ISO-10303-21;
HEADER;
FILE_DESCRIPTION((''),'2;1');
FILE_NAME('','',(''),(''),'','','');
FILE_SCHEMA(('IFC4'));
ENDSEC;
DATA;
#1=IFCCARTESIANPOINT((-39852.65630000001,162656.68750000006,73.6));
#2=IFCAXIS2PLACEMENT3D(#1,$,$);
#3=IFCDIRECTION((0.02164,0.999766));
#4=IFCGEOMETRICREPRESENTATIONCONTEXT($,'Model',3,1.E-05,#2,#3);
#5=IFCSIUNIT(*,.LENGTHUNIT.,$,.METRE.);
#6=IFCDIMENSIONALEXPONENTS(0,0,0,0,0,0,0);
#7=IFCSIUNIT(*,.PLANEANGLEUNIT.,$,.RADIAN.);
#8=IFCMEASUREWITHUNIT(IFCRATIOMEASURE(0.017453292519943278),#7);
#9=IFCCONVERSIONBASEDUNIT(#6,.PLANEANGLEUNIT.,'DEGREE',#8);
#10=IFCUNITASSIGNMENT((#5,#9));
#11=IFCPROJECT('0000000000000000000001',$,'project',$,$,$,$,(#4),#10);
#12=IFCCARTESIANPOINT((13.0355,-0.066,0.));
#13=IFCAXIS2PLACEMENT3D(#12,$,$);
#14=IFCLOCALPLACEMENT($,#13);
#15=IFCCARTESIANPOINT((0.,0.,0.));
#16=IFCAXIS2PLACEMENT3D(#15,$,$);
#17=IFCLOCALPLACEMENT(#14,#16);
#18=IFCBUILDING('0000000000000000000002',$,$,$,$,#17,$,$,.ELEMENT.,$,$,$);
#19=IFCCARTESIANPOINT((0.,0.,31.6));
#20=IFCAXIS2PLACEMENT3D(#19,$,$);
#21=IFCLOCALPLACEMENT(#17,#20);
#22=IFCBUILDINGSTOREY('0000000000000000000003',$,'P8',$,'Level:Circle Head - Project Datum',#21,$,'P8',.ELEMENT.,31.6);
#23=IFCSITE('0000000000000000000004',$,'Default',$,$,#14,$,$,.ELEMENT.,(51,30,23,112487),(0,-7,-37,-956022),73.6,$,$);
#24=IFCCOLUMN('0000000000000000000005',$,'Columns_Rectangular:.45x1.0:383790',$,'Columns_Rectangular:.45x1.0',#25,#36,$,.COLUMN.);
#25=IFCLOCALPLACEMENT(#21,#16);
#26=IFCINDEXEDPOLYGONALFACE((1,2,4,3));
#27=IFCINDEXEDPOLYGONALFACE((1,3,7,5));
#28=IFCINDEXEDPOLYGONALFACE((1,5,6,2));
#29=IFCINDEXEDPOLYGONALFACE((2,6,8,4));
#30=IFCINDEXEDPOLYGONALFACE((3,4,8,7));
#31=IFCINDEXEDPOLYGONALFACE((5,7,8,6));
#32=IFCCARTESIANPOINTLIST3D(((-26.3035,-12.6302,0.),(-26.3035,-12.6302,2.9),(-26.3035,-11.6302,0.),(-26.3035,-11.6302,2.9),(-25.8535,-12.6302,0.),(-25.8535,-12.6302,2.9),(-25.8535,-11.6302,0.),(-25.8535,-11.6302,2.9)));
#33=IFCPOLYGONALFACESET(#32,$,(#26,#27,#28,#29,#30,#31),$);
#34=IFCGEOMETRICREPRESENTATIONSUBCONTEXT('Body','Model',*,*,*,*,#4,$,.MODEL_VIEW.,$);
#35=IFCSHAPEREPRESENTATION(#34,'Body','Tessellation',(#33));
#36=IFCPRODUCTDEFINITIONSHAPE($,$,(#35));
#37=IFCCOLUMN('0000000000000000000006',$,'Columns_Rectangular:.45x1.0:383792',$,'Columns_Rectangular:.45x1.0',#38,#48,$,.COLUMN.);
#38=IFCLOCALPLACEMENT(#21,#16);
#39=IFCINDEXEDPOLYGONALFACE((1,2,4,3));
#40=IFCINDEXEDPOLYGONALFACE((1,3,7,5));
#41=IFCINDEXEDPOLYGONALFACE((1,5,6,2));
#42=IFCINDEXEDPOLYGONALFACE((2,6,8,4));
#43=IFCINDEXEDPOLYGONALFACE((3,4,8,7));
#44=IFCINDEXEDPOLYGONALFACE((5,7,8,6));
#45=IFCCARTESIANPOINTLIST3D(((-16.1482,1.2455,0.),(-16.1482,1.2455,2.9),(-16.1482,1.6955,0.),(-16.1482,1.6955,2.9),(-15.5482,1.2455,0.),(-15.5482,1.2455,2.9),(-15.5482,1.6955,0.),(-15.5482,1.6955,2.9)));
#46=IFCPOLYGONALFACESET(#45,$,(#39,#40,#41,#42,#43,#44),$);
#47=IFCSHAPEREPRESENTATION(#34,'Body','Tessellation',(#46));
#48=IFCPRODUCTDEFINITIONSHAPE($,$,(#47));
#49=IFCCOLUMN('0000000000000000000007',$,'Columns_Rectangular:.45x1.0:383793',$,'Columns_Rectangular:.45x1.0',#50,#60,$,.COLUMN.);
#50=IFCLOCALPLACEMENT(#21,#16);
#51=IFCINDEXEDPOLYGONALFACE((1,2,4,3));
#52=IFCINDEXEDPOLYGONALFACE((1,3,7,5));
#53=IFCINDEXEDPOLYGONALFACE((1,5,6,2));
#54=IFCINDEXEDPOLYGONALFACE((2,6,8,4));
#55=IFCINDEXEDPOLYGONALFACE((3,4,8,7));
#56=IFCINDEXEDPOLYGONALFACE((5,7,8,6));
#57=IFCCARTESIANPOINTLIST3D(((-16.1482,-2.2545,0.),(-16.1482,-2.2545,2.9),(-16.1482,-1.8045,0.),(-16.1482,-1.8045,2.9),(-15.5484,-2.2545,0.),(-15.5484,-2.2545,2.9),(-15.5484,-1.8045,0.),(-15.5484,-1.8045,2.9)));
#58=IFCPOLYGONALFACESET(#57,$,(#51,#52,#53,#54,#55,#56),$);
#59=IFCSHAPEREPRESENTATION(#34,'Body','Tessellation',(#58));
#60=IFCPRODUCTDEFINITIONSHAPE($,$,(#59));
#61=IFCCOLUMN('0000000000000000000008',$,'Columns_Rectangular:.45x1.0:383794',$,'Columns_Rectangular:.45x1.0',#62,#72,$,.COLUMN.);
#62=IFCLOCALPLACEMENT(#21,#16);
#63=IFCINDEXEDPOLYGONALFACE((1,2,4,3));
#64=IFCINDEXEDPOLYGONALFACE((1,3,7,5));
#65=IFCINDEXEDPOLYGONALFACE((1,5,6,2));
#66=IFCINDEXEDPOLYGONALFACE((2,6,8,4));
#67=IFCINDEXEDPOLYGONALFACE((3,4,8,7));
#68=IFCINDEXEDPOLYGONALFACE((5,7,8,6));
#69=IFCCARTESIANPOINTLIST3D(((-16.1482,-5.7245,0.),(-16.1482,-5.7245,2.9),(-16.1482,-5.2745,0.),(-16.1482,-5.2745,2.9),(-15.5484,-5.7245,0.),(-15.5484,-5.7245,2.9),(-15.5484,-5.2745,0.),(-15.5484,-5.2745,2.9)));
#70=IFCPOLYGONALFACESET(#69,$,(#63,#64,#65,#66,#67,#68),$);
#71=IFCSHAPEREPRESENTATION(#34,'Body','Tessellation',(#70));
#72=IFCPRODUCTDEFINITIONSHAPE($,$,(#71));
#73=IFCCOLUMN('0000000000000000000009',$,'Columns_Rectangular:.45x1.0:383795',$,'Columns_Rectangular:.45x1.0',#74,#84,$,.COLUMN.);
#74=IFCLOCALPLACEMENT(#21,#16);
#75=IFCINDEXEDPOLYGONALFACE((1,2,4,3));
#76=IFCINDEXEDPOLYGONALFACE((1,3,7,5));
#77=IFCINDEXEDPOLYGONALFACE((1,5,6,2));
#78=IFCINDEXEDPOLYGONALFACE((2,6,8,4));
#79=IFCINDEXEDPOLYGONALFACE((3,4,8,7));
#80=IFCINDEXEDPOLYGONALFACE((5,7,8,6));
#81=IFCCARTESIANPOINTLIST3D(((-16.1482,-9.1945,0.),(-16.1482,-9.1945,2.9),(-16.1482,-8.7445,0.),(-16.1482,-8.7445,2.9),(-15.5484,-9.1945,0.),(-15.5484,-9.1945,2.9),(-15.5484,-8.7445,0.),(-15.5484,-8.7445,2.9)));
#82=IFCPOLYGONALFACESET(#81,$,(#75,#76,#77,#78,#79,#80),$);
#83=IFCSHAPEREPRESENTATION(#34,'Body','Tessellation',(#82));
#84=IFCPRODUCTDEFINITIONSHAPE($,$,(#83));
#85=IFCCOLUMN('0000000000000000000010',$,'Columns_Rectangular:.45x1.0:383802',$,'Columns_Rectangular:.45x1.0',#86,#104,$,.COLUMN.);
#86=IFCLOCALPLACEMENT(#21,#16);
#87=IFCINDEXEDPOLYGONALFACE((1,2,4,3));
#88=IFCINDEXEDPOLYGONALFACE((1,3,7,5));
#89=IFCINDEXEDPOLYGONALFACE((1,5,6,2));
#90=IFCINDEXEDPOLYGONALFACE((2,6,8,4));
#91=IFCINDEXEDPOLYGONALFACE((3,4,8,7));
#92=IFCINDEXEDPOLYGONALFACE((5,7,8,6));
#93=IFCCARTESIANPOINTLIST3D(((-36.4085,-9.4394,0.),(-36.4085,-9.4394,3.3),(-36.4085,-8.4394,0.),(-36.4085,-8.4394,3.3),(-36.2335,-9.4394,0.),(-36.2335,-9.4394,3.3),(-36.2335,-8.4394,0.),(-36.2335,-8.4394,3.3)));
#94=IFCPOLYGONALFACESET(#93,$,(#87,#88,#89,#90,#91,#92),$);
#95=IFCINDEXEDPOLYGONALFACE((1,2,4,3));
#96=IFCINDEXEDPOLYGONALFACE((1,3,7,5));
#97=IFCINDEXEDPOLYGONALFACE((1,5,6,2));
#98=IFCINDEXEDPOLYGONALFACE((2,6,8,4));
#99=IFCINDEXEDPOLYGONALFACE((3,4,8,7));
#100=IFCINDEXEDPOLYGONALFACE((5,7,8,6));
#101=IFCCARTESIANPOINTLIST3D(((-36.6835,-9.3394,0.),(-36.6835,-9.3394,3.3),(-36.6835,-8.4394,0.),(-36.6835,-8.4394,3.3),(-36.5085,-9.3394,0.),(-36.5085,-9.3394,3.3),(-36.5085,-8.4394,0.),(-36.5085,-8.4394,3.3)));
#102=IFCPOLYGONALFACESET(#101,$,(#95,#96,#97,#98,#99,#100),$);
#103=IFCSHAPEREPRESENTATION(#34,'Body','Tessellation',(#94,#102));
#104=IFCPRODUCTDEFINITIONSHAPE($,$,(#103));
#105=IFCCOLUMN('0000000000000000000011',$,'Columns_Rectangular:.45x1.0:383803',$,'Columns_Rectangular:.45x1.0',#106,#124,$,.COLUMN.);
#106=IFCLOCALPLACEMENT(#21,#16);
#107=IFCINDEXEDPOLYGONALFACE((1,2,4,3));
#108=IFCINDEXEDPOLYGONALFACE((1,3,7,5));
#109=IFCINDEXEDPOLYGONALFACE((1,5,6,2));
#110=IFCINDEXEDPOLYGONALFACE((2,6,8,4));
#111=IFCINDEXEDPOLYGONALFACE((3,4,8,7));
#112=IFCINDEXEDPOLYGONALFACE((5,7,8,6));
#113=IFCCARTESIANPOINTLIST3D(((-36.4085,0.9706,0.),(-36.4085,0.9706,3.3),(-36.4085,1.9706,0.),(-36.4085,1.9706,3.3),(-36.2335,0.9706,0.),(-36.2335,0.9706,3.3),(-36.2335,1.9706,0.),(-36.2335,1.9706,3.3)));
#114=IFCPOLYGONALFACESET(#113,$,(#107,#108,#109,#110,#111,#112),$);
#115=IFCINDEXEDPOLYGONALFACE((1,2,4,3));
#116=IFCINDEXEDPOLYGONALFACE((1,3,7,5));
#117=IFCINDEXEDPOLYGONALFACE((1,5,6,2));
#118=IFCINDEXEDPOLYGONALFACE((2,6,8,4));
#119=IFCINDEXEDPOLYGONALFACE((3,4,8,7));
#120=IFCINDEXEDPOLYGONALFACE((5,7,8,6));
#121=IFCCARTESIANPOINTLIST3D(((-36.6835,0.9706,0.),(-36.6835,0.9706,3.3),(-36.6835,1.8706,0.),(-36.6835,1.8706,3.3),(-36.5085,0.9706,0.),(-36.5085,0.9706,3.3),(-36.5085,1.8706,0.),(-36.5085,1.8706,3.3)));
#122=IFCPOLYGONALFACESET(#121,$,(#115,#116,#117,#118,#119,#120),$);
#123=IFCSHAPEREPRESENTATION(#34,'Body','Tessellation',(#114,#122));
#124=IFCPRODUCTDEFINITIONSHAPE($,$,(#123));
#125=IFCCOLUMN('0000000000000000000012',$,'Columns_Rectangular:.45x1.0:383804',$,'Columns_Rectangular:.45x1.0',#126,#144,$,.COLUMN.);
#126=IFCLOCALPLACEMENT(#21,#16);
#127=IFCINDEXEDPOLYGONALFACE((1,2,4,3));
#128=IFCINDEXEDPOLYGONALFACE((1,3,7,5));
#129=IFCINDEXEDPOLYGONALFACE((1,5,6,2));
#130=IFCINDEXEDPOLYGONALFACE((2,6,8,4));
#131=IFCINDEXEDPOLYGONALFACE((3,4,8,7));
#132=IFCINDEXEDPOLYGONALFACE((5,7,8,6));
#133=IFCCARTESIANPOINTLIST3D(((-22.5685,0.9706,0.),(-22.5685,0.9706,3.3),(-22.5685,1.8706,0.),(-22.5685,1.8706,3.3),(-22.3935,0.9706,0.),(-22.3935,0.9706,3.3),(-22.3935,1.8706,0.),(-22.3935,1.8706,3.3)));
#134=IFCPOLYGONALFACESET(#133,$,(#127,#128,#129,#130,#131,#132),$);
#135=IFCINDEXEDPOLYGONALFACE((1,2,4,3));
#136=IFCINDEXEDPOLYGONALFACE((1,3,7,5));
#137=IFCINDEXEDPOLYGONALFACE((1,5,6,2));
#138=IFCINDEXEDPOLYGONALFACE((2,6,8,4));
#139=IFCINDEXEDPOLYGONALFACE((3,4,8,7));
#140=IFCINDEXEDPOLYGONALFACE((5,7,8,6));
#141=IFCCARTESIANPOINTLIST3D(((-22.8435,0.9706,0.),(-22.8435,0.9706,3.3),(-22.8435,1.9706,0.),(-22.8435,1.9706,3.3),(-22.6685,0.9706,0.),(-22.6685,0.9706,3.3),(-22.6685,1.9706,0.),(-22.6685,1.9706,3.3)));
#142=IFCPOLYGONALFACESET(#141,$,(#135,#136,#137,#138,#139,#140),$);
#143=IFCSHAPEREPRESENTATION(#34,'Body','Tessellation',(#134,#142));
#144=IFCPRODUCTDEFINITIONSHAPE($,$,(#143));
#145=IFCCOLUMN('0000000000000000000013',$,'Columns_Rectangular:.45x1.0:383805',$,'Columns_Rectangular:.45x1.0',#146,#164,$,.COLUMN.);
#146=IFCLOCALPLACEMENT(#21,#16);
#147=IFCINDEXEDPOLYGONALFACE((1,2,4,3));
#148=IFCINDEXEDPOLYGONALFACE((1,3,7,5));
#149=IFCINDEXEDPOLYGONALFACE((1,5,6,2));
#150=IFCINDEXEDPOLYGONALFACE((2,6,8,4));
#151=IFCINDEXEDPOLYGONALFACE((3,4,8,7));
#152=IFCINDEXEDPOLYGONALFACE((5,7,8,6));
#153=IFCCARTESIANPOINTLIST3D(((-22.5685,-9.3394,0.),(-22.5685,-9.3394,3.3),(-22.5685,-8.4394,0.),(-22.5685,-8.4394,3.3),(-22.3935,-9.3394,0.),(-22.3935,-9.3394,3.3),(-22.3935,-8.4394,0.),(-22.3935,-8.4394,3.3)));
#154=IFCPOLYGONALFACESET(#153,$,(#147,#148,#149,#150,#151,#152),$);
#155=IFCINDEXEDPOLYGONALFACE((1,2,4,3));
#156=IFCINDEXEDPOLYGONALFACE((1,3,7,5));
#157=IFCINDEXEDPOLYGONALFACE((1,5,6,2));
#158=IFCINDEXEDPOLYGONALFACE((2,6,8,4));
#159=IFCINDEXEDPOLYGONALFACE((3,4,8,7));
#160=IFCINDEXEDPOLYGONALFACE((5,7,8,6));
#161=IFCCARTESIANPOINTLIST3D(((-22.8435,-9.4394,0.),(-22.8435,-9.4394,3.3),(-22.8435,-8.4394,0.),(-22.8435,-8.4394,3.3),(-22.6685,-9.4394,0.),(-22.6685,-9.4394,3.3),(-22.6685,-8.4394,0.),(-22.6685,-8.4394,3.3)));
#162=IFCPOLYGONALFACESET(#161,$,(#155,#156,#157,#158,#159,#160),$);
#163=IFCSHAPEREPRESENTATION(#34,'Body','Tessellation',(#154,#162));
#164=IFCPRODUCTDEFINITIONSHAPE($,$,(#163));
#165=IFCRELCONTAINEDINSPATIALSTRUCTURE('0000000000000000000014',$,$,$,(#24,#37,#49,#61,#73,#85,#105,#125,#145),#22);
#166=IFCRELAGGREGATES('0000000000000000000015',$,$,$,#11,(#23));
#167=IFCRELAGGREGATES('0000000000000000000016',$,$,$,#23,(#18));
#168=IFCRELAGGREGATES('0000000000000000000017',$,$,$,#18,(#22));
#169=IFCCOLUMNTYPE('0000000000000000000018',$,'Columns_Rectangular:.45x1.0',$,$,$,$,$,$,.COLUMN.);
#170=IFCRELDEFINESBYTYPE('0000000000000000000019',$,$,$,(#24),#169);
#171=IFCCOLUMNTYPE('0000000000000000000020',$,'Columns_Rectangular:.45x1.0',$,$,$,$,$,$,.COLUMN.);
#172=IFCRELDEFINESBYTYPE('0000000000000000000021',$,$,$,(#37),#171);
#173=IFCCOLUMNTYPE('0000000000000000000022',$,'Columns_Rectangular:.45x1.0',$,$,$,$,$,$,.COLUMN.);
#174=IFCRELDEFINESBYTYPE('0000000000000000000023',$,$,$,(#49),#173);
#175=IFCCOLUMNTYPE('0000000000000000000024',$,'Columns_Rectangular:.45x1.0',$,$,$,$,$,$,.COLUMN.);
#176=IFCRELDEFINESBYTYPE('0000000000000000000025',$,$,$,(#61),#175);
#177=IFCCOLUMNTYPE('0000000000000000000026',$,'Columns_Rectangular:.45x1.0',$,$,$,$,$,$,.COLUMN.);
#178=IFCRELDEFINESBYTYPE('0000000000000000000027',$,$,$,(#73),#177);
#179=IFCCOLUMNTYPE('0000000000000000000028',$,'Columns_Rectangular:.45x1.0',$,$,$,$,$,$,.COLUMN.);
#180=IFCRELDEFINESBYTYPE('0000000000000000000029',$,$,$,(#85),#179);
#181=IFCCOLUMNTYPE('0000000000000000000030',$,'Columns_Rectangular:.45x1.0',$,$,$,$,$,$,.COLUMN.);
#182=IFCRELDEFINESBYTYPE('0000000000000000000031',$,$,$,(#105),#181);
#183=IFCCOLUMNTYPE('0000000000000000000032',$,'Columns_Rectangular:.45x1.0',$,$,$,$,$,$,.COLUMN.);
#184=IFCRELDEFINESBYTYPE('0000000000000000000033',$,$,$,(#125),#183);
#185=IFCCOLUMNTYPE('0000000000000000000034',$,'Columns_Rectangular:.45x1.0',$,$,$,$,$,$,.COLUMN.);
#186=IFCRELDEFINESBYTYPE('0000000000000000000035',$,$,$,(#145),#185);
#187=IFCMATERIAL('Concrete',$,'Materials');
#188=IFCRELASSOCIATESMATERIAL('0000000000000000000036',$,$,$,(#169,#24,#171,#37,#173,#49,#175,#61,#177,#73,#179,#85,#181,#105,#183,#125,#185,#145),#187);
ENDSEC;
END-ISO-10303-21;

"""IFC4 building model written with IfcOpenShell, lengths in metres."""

from ifc_helpers import new_model, entity, si_unit, converted_unit, direction, frame, origin, place, context, subcontext, project, spatial, indexed_curve, outline, extrude, source, transform, mapped, material, type_object, type_shapes, element, save


model = new_model("IFC4")

# Units and contexts
model_context = context("Model", 3, precision=1e-05, world=frame((-39852.65630000001, 162656.68750000006, 73.6)), true_north=direction((0.02164, 0.999766)))
body_context = subcontext(model_context, "Body", "Model", "MODEL_VIEW")
ifc_project = project(units=[si_unit("LENGTHUNIT", "METRE"), converted_unit("PLANEANGLEUNIT", "DEGREE", entity("IfcRatioMeasure", 0.017453292519943278), si_unit("PLANEANGLEUNIT", "RADIAN"), dimensions=[0, 0, 0, 0, 0, 0, 0])], contexts=[model_context])

# Site, building, storey
site_placement = place(None, frame((13.0355, -0.066, 0.0)))
site = spatial("IfcSite", under=ifc_project, at=site_placement, Name="Default", CompositionType="ELEMENT", RefLatitude=(51, 30, 23, 112487), RefLongitude=(0, -7, -37, -956022), RefElevation=73.6)
building_placement = place(site_placement, origin())
building = spatial("IfcBuilding", under=site, at=building_placement, CompositionType="ELEMENT")
storey_placement = place(building_placement, frame((0.0, 0.0, 31.6)))
storey = spatial("IfcBuildingStorey", under=building, at=storey_placement, Name="P8", ObjectType="Level:Circle Head - Project Datum", LongName="P8", CompositionType="ELEMENT", Elevation=31.6)

# Columns
ifc_material = material(Name="Concrete", Category="Materials")
column_type_1 = type_object("IfcColumnType", Name="Columns_Rectangular:.45x1.0", PredefinedType="COLUMN", material=ifc_material)
shared_shape_1 = source(origin(), body_context, "Body", "SweptSolid", [
    extrude(outline(indexed_curve([(-0.5, -0.225), (0.5, -0.225), (0.5, 0.225), (-0.5, 0.225), (-0.5, -0.225)], self_intersect=False)), frame((-26.0785, -12.1302, 31.6), z_axis=(0.0, 0.0, 1.0), x_axis=(0.000011, 1.0, 0.0)), (0.0, 0.0, 1.0), 2.9),
])
type_shapes(column_type_1, [shared_shape_1])
column_1_placement = place(storey_placement, frame((0.0, 0.0, -31.6)))
element("IfcColumn", 1, at=column_1_placement, inside=storey, type_object=column_type_1, material=ifc_material, Name="Columns_Rectangular:.45x1.0:383790", ObjectType="Columns_Rectangular:.45x1.0", PredefinedType="COLUMN", context=body_context, shape_type="MappedRepresentation", body=[
    mapped(shared_shape_1, transform((0.0, 0.0, 0.0), scale=1.0)),
])
column_type_2 = type_object("IfcColumnType", Name="Columns_Rectangular:.45x1.0", PredefinedType="COLUMN", material=ifc_material)
shared_shape_2 = source(origin(), body_context, "Body", "SweptSolid", [
    extrude(outline(indexed_curve([(-0.225, -0.3), (0.225, -0.3), (0.225, 0.3), (-0.225, 0.3), (-0.225, -0.3)], self_intersect=False)), frame((-15.8482, 1.4705, 31.6), z_axis=(0.0, 0.0, 1.0), x_axis=(0.0, -1.0, 0.0)), (0.0, 0.0, 1.0), 2.9),
])
type_shapes(column_type_2, [shared_shape_2])
column_2_placement = place(storey_placement, frame((0.0, 0.0, -31.6)))
element("IfcColumn", 2, at=column_2_placement, inside=storey, type_object=column_type_2, material=ifc_material, Name="Columns_Rectangular:.45x1.0:383792", ObjectType="Columns_Rectangular:.45x1.0", PredefinedType="COLUMN", context=body_context, shape_type="MappedRepresentation", body=[
    mapped(shared_shape_2, transform((0.0, 0.0, 0.0), scale=1.0)),
])
column_type_3 = type_object("IfcColumnType", Name="Columns_Rectangular:.45x1.0", PredefinedType="COLUMN", material=ifc_material)
shared_shape_3 = source(origin(), body_context, "Body", "SweptSolid", [
    extrude(outline(indexed_curve([(-0.225, -0.2999), (0.225, -0.2999), (0.225, 0.2999), (-0.225, 0.2999), (-0.225, -0.2999)], self_intersect=False)), frame((-15.8483, -2.0295, 31.6), z_axis=(0.0, 0.0, 1.0), x_axis=(0.0, -1.0, 0.0)), (0.0, 0.0, 1.0), 2.9),
])
type_shapes(column_type_3, [shared_shape_3])
column_3_placement = place(storey_placement, frame((0.0, 0.0, -31.6)))
element("IfcColumn", 3, at=column_3_placement, inside=storey, type_object=column_type_3, material=ifc_material, Name="Columns_Rectangular:.45x1.0:383793", ObjectType="Columns_Rectangular:.45x1.0", PredefinedType="COLUMN", context=body_context, shape_type="MappedRepresentation", body=[
    mapped(shared_shape_3, transform((0.0, 0.0, 0.0), scale=1.0)),
])
column_type_4 = type_object("IfcColumnType", Name="Columns_Rectangular:.45x1.0", PredefinedType="COLUMN", material=ifc_material)
shared_shape_4 = source(origin(), body_context, "Body", "SweptSolid", [
    extrude(outline(indexed_curve([(-0.225, -0.2999), (0.225, -0.2999), (0.225, 0.2999), (-0.225, 0.2999), (-0.225, -0.2999)], self_intersect=False)), frame((-15.8483, -5.4995, 31.6), z_axis=(0.0, 0.0, 1.0), x_axis=(0.0, -1.0, 0.0)), (0.0, 0.0, 1.0), 2.9),
])
type_shapes(column_type_4, [shared_shape_4])
column_4_placement = place(storey_placement, frame((0.0, 0.0, -31.6)))
element("IfcColumn", 4, at=column_4_placement, inside=storey, type_object=column_type_4, material=ifc_material, Name="Columns_Rectangular:.45x1.0:383794", ObjectType="Columns_Rectangular:.45x1.0", PredefinedType="COLUMN", context=body_context, shape_type="MappedRepresentation", body=[
    mapped(shared_shape_4, transform((0.0, 0.0, 0.0), scale=1.0)),
])
column_type_5 = type_object("IfcColumnType", Name="Columns_Rectangular:.45x1.0", PredefinedType="COLUMN", material=ifc_material)
shared_shape_5 = source(origin(), body_context, "Body", "SweptSolid", [
    extrude(outline(indexed_curve([(-0.225, -0.2999), (0.225, -0.2999), (0.225, 0.2999), (-0.225, 0.2999), (-0.225, -0.2999)], self_intersect=False)), frame((-15.8483, -8.9695, 31.6), z_axis=(0.0, 0.0, 1.0), x_axis=(0.0, -1.0, 0.0)), (0.0, 0.0, 1.0), 2.9),
])
type_shapes(column_type_5, [shared_shape_5])
column_5_placement = place(storey_placement, frame((0.0, 0.0, -31.6)))
element("IfcColumn", 5, at=column_5_placement, inside=storey, type_object=column_type_5, material=ifc_material, Name="Columns_Rectangular:.45x1.0:383795", ObjectType="Columns_Rectangular:.45x1.0", PredefinedType="COLUMN", context=body_context, shape_type="MappedRepresentation", body=[
    mapped(shared_shape_5, transform((0.0, 0.0, 0.0), scale=1.0)),
])
column_type_6 = type_object("IfcColumnType", Name="Columns_Rectangular:.45x1.0", PredefinedType="COLUMN", material=ifc_material)
shared_shape_6 = source(origin(), body_context, "Body", "SweptSolid", [
    extrude(outline(indexed_curve([(-0.5, -0.0875), (0.5, -0.0875), (0.5, 0.0875), (-0.5, 0.0875), (-0.5, -0.0875)], self_intersect=False)), frame((-36.321, -8.9394, 31.6), z_axis=(0.0, 0.0, 1.0), x_axis=(0.0, -1.0, 0.0)), (0.0, 0.0, 1.0), 3.3),
    extrude(outline(indexed_curve([(-0.45, -0.0875), (0.45, -0.0875), (0.45, 0.0875), (-0.45, 0.0875), (-0.45, -0.0875)], self_intersect=False)), frame((-36.596, -8.8894, 31.6), z_axis=(0.0, 0.0, 1.0), x_axis=(0.0, -1.0, 0.0)), (0.0, 0.0, 1.0), 3.3),
])
type_shapes(column_type_6, [shared_shape_6])
column_6_placement = place(storey_placement, frame((0.0, 0.0, -31.6)))
element("IfcColumn", 6, at=column_6_placement, inside=storey, type_object=column_type_6, material=ifc_material, Name="Columns_Rectangular:.45x1.0:383802", ObjectType="Columns_Rectangular:.45x1.0", PredefinedType="COLUMN", context=body_context, shape_type="MappedRepresentation", body=[
    mapped(shared_shape_6, transform((0.0, 0.0, 0.0), scale=1.0)),
])
column_type_7 = type_object("IfcColumnType", Name="Columns_Rectangular:.45x1.0", PredefinedType="COLUMN", material=ifc_material)
shared_shape_7 = source(origin(), body_context, "Body", "SweptSolid", [
    extrude(outline(indexed_curve([(-0.5, -0.0875), (0.5, -0.0875), (0.5, 0.0875), (-0.5, 0.0875), (-0.5, -0.0875)], self_intersect=False)), frame((-36.321, 1.4706, 31.6), z_axis=(0.0, 0.0, 1.0), x_axis=(0.0, -1.0, 0.0)), (0.0, 0.0, 1.0), 3.3),
    extrude(outline(indexed_curve([(-0.45, -0.0875), (0.45, -0.0875), (0.45, 0.0875), (-0.45, 0.0875), (-0.45, -0.0875)], self_intersect=False)), frame((-36.596, 1.4206, 31.6), z_axis=(0.0, 0.0, 1.0), x_axis=(0.0, -1.0, 0.0)), (0.0, 0.0, 1.0), 3.3),
])
type_shapes(column_type_7, [shared_shape_7])
column_7_placement = place(storey_placement, frame((0.0, 0.0, -31.6)))
element("IfcColumn", 7, at=column_7_placement, inside=storey, type_object=column_type_7, material=ifc_material, Name="Columns_Rectangular:.45x1.0:383803", ObjectType="Columns_Rectangular:.45x1.0", PredefinedType="COLUMN", context=body_context, shape_type="MappedRepresentation", body=[
    mapped(shared_shape_7, transform((0.0, 0.0, 0.0), scale=1.0)),
])
column_type_8 = type_object("IfcColumnType", Name="Columns_Rectangular:.45x1.0", PredefinedType="COLUMN", material=ifc_material)
shared_shape_8 = source(origin(), body_context, "Body", "SweptSolid", [
    extrude(outline(indexed_curve([(-0.45, -0.0875), (0.45, -0.0875), (0.45, 0.0875), (-0.45, 0.0875), (-0.45, -0.0875)], self_intersect=False)), frame((-22.481, 1.4206, 31.6), z_axis=(0.0, 0.0, 1.0), x_axis=(0.0, -1.0, 0.0)), (0.0, 0.0, 1.0), 3.3),
    extrude(outline(indexed_curve([(-0.5, -0.0875), (0.5, -0.0875), (0.5, 0.0875), (-0.5, 0.0875), (-0.5, -0.0875)], self_intersect=False)), frame((-22.756, 1.4706, 31.6), z_axis=(0.0, 0.0, 1.0), x_axis=(0.0, -1.0, 0.0)), (0.0, 0.0, 1.0), 3.3),
])
type_shapes(column_type_8, [shared_shape_8])
column_8_placement = place(storey_placement, frame((0.0, 0.0, -31.6)))
element("IfcColumn", 8, at=column_8_placement, inside=storey, type_object=column_type_8, material=ifc_material, Name="Columns_Rectangular:.45x1.0:383804", ObjectType="Columns_Rectangular:.45x1.0", PredefinedType="COLUMN", context=body_context, shape_type="MappedRepresentation", body=[
    mapped(shared_shape_8, transform((0.0, 0.0, 0.0), scale=1.0)),
])
column_type_9 = type_object("IfcColumnType", Name="Columns_Rectangular:.45x1.0", PredefinedType="COLUMN", material=ifc_material)
shared_shape_9 = source(origin(), body_context, "Body", "SweptSolid", [
    extrude(outline(indexed_curve([(-0.45, -0.0875), (0.45, -0.0875), (0.45, 0.0875), (-0.45, 0.0875), (-0.45, -0.0875)], self_intersect=False)), frame((-22.481, -8.8894, 31.6), z_axis=(0.0, 0.0, 1.0), x_axis=(0.0, -1.0, 0.0)), (0.0, 0.0, 1.0), 3.3),
    extrude(outline(indexed_curve([(-0.5, -0.0875), (0.5, -0.0875), (0.5, 0.0875), (-0.5, 0.0875), (-0.5, -0.0875)], self_intersect=False)), frame((-22.756, -8.9394, 31.6), z_axis=(0.0, 0.0, 1.0), x_axis=(0.0, -1.0, 0.0)), (0.0, 0.0, 1.0), 3.3),
])
type_shapes(column_type_9, [shared_shape_9])
column_9_placement = place(storey_placement, frame((0.0, 0.0, -31.6)))
element("IfcColumn", 9, at=column_9_placement, inside=storey, type_object=column_type_9, material=ifc_material, Name="Columns_Rectangular:.45x1.0:383805", ObjectType="Columns_Rectangular:.45x1.0", PredefinedType="COLUMN", context=body_context, shape_type="MappedRepresentation", body=[
    mapped(shared_shape_9, transform((0.0, 0.0, 0.0), scale=1.0)),
])

save(model, "model.ifc")
